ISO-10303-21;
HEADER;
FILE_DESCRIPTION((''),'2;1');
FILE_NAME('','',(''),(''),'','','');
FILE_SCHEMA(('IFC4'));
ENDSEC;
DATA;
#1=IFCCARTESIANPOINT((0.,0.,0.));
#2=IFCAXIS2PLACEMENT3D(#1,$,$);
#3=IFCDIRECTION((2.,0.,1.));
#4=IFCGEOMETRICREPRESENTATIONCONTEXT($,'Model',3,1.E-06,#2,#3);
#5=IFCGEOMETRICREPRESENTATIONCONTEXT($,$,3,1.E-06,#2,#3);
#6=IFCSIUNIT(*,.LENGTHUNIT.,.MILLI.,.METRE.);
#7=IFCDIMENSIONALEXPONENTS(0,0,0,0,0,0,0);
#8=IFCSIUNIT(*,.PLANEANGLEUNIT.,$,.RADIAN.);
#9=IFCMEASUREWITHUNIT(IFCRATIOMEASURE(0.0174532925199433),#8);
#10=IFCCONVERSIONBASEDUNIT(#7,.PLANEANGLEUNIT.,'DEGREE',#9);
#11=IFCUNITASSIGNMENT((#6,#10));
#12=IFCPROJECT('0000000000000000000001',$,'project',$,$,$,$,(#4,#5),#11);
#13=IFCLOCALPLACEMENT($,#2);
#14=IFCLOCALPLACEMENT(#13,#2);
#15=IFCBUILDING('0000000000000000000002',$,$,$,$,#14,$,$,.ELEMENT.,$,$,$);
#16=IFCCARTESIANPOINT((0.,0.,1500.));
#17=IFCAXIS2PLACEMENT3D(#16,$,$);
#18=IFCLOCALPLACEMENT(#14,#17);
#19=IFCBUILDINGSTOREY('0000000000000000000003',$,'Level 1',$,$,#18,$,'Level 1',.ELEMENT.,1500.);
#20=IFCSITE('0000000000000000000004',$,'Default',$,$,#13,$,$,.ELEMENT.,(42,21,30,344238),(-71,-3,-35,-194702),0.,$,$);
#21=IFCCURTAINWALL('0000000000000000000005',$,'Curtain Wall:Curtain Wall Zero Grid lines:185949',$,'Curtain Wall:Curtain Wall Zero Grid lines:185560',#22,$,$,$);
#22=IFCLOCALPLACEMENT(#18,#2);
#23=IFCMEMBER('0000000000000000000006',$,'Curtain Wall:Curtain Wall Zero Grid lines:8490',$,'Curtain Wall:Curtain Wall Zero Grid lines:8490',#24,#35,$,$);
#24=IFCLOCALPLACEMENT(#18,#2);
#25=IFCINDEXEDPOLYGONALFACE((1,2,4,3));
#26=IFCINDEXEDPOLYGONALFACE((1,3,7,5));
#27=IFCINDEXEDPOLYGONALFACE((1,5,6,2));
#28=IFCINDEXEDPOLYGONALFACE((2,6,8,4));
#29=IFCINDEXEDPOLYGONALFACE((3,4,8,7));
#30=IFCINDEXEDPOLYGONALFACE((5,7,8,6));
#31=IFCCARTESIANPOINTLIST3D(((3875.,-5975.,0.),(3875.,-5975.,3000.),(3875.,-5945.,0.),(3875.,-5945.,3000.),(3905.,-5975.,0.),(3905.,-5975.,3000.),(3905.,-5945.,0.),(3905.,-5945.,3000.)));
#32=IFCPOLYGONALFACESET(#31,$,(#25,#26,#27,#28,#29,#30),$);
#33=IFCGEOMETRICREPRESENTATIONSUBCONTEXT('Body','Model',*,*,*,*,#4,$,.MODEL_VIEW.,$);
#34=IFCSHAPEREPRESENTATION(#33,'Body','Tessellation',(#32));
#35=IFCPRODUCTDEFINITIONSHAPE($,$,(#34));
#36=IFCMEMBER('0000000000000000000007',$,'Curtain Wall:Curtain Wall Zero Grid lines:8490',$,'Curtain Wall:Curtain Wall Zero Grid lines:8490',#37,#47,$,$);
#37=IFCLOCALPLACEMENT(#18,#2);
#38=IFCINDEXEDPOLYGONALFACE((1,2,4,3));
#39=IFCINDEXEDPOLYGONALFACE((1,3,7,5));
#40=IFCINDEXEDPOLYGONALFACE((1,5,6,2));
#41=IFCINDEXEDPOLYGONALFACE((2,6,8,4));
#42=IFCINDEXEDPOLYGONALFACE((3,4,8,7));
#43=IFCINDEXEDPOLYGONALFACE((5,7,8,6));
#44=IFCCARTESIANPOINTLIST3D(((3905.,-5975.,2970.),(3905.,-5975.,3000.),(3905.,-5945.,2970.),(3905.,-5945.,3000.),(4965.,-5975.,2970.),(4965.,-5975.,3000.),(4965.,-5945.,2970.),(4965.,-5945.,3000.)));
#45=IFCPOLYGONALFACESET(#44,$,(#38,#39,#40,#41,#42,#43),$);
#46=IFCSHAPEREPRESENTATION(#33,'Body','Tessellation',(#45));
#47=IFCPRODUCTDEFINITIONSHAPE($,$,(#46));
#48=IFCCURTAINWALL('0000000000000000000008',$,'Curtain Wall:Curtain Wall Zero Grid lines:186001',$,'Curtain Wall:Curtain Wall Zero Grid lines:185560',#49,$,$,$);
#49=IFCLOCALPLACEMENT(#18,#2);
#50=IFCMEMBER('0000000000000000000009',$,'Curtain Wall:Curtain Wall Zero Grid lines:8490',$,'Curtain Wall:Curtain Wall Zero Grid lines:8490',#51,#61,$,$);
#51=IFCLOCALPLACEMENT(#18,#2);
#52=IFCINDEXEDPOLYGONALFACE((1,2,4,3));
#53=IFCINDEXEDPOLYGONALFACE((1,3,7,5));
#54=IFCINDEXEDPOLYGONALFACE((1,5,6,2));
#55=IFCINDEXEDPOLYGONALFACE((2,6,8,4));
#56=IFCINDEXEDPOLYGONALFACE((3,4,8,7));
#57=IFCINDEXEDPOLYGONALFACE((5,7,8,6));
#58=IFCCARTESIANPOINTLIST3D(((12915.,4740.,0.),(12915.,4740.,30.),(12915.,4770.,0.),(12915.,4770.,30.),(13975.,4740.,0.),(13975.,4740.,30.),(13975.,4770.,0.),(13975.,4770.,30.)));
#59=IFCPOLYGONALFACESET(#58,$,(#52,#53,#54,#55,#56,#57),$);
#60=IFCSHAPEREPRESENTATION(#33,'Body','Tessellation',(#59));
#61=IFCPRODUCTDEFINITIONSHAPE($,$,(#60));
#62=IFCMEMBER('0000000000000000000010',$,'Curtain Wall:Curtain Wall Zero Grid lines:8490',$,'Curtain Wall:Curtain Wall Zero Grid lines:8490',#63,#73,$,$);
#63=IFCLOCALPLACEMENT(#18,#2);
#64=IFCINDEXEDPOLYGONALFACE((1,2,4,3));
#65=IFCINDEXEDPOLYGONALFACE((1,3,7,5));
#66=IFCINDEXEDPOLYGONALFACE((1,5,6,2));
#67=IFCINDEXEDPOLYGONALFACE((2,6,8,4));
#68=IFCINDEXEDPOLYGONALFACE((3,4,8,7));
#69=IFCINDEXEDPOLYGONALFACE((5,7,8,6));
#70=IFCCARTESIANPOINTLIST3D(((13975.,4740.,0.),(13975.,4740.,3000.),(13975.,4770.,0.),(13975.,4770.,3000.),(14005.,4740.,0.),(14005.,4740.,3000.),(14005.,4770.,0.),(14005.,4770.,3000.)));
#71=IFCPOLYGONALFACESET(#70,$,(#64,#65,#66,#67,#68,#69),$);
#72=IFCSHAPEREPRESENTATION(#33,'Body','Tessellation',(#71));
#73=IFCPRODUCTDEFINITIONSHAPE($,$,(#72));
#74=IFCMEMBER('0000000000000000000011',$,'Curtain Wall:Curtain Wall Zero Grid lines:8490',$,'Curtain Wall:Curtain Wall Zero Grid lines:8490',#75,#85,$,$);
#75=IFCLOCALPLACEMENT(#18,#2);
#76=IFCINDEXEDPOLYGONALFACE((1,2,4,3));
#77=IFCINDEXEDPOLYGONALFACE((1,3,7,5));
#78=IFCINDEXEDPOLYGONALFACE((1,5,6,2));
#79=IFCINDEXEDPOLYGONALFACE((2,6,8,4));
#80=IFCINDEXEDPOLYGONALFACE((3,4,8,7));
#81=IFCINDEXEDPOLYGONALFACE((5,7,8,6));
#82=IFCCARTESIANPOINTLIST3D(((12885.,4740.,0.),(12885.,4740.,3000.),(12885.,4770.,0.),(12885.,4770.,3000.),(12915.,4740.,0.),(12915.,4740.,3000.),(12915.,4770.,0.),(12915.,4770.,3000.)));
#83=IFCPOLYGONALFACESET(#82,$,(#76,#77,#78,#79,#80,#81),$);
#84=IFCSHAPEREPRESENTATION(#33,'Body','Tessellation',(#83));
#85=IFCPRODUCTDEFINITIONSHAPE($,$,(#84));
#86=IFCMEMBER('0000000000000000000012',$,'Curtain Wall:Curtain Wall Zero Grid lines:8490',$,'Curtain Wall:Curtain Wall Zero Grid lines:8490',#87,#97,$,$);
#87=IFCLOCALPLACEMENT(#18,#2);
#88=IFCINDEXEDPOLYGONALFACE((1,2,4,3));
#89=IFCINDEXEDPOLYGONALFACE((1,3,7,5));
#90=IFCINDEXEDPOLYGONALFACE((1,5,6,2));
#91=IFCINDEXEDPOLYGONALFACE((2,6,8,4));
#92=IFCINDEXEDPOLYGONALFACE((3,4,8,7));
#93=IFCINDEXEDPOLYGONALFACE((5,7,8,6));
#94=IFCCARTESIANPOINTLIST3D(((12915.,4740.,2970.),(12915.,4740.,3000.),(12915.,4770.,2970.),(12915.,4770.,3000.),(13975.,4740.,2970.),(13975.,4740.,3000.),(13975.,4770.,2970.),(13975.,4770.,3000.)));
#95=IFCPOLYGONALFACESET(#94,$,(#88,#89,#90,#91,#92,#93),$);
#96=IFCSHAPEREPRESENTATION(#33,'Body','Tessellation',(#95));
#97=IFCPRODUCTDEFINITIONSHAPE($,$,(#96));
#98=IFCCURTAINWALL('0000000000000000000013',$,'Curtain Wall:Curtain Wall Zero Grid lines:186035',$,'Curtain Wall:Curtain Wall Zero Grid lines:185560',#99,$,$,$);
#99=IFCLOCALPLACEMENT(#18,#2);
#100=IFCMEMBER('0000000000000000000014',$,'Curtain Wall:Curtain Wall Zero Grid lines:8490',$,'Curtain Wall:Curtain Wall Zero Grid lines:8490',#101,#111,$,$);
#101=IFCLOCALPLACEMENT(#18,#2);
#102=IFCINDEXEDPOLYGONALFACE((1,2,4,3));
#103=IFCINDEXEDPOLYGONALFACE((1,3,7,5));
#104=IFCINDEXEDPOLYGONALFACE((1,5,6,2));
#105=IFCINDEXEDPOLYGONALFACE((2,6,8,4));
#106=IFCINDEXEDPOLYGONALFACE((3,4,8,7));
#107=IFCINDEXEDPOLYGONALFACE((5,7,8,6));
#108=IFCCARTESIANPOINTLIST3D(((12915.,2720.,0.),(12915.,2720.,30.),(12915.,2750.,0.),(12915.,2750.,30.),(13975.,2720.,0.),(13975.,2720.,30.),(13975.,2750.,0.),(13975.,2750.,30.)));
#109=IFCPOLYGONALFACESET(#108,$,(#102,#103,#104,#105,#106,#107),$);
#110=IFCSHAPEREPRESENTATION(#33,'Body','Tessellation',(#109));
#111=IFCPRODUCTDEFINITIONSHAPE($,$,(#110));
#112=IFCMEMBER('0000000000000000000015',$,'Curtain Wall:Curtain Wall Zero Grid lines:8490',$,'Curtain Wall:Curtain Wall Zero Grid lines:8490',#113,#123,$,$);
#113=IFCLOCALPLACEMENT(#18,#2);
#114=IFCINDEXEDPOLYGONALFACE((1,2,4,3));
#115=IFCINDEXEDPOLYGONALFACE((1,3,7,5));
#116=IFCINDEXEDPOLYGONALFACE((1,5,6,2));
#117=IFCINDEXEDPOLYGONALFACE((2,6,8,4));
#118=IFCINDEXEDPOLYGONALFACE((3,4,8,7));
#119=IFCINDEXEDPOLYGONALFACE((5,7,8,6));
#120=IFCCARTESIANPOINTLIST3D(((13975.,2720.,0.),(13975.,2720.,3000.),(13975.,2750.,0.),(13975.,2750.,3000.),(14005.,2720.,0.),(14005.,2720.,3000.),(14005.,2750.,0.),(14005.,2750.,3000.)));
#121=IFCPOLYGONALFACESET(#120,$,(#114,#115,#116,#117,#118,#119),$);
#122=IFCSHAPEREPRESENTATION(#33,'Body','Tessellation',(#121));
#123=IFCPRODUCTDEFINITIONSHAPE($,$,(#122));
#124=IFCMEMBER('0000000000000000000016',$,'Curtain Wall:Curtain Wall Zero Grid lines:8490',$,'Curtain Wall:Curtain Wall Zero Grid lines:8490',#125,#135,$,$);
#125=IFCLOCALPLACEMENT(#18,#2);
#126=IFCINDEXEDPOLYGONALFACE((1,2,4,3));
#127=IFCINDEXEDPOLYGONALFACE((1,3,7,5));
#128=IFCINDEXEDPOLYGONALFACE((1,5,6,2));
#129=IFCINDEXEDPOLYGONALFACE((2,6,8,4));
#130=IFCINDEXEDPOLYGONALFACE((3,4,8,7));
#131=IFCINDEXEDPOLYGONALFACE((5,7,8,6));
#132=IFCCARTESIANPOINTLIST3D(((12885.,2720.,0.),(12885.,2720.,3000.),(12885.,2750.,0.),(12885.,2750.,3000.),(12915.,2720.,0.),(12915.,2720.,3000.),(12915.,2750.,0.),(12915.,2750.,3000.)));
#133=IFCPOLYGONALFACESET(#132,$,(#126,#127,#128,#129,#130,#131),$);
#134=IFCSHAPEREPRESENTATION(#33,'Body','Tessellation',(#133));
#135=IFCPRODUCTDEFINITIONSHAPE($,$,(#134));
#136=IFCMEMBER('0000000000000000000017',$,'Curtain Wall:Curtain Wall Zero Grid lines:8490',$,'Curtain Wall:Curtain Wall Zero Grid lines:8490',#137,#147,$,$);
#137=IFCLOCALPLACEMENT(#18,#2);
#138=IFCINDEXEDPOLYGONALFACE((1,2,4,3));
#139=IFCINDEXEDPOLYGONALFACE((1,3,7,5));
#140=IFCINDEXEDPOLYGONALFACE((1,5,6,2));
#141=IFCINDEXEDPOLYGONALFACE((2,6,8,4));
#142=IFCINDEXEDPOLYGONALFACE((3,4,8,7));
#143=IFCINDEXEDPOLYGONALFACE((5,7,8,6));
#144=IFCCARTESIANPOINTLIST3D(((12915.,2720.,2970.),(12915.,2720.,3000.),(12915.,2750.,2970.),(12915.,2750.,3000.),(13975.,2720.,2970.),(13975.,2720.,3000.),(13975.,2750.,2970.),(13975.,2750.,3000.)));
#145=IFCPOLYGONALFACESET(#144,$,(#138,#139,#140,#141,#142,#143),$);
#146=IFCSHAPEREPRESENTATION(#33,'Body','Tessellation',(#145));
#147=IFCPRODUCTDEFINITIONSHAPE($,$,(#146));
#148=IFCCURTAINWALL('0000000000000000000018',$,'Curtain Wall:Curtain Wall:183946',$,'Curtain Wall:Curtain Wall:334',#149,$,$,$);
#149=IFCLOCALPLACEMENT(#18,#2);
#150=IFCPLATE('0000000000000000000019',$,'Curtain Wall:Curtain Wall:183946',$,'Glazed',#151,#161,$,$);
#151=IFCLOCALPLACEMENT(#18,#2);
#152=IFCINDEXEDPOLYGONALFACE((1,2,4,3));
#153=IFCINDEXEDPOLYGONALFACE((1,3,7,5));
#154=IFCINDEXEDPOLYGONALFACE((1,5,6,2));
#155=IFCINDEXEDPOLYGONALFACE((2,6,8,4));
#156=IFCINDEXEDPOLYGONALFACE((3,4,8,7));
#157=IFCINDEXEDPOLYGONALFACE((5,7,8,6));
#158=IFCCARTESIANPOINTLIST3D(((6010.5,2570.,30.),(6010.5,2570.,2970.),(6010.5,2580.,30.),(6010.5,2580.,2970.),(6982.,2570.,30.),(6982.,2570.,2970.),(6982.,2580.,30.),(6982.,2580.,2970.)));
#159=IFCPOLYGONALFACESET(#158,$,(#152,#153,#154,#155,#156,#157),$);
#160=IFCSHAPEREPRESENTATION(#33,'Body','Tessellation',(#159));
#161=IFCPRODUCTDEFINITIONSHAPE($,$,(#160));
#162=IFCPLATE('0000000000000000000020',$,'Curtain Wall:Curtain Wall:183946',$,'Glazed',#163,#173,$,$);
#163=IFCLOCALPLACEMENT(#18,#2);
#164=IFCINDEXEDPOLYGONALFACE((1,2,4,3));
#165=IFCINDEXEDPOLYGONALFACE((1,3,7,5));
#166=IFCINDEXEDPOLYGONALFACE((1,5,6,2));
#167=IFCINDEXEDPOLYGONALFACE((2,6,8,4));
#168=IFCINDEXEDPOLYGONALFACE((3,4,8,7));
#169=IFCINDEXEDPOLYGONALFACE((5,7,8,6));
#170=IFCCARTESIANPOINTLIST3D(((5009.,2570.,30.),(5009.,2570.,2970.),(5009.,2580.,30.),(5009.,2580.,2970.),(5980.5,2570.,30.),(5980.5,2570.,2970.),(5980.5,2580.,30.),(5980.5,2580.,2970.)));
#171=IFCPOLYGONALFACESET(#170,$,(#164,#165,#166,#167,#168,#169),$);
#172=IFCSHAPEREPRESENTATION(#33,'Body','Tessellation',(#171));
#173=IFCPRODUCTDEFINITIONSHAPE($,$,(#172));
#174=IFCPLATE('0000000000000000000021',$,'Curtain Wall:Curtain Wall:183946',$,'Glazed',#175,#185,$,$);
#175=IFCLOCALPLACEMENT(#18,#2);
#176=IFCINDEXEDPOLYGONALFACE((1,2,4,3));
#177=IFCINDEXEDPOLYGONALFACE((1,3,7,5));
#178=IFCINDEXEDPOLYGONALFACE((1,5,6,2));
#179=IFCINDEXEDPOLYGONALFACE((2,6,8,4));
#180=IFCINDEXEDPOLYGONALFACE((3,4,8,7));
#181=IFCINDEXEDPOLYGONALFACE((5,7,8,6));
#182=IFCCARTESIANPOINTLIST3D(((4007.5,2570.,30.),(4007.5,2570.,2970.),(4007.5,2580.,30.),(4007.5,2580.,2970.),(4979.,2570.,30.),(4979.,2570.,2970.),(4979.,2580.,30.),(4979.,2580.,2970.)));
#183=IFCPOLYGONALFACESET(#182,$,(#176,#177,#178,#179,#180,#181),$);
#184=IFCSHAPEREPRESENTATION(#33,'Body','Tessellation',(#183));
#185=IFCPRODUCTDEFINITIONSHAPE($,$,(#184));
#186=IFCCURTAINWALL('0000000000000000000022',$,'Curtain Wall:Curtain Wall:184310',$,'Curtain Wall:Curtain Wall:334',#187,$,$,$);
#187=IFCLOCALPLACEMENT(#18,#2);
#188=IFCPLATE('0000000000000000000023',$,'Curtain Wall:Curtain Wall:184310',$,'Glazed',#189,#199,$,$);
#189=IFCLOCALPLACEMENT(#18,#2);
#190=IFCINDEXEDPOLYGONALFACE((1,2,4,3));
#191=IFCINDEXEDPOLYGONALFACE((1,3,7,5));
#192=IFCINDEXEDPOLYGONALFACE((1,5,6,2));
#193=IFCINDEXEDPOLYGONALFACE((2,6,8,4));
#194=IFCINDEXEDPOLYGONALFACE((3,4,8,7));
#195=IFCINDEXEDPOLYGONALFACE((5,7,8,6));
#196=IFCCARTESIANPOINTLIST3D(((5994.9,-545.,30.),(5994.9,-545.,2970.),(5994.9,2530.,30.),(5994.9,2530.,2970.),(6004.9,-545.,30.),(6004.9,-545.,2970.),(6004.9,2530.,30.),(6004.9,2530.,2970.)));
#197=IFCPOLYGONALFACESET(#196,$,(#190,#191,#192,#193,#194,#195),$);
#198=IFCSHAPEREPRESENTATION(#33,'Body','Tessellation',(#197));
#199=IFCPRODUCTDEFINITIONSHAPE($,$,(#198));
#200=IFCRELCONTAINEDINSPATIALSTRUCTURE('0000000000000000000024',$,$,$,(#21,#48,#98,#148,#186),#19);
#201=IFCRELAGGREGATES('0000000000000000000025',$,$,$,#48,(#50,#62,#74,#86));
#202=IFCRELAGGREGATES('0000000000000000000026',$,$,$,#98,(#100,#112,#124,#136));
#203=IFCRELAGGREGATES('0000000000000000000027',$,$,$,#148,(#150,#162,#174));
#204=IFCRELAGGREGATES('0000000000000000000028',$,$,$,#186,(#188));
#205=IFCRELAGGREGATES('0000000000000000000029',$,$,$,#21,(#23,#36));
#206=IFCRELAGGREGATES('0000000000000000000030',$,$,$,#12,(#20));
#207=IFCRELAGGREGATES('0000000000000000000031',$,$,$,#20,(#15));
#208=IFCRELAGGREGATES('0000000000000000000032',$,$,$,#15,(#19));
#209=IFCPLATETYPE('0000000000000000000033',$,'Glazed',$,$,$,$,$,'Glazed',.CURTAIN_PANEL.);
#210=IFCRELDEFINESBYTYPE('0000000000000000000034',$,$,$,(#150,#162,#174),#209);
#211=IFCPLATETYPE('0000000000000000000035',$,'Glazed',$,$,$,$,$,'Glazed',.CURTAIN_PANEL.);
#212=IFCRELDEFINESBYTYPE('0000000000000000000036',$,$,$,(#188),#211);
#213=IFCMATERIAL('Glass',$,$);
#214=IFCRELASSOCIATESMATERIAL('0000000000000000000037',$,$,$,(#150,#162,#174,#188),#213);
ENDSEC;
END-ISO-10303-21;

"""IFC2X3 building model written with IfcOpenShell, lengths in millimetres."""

from ifc_helpers import new_model, entity, si_unit, converted_unit, direction, frame, frame_2d, origin, origin_2d_with_axis, place, context, subcontext, project, spatial, rectangle, extrude, source, transform, mapped, material, type_object, type_shapes, element, aggregate, save


model = new_model("IFC2X3")

# Units and contexts
model_context = context("Model", 3, precision=1e-06, world=origin(), true_north=direction((2.0, 0.0, 1.0)))
context_of_model = context(None, 3, precision=1e-06, world=origin(), true_north=direction((2.0, 0.0, 1.0)))
body_context = subcontext(model_context, "Body", "Model", "MODEL_VIEW")
ifc_project = project(units=[si_unit("LENGTHUNIT", "METRE", prefix="MILLI"), converted_unit("PLANEANGLEUNIT", "DEGREE", entity("IfcRatioMeasure", 0.0174532925199433), si_unit("PLANEANGLEUNIT", "RADIAN"), dimensions=[0, 0, 0, 0, 0, 0, 0])], contexts=[model_context, context_of_model])

# Site, building, storey
site_placement = place(None, origin())
site = spatial("IfcSite", under=ifc_project, at=site_placement, Name="Default", CompositionType="ELEMENT", RefLatitude=(42, 21, 30, 344238), RefLongitude=(-71, -3, -35, -194702), RefElevation=0.0)
building_placement = place(site_placement, origin())
building = spatial("IfcBuilding", under=site, at=building_placement, CompositionType="ELEMENT")
storey_placement = place(building_placement, frame((0.0, 0.0, 1500.0)))
storey = spatial("IfcBuildingStorey", under=building, at=storey_placement, Name="Level 1", LongName="Level 1", CompositionType="ELEMENT", Elevation=1500.0)

# Curtain walls, members
curtain_wall_1_placement = place(storey_placement, origin())
curtain_wall_1 = element("IfcCurtainWall", 1, at=curtain_wall_1_placement, inside=storey, Name="Curtain Wall:Curtain Wall Zero Grid lines:185949", ObjectType="Curtain Wall:Curtain Wall Zero Grid lines:185560")
member_1_placement = place(storey_placement, origin())
member_1 = element("IfcMember", 2, at=member_1_placement, Name="Curtain Wall:Curtain Wall Zero Grid lines:8490", ObjectType="Curtain Wall:Curtain Wall Zero Grid lines:8490", context=body_context, shape_type="SweptSolid", body=[
    extrude(rectangle(XDim=30.0, YDim=30.0, at=origin_2d_with_axis()), frame((3890.0, -5960.0, 0.0)), (0.0, 0.0, 1.0), 3000.0),
])
member_2_placement = place(storey_placement, origin())
member_2 = element("IfcMember", 3, at=member_2_placement, Name="Curtain Wall:Curtain Wall Zero Grid lines:8490", ObjectType="Curtain Wall:Curtain Wall Zero Grid lines:8490", context=body_context, shape_type="SweptSolid", body=[
    extrude(rectangle(XDim=1060.0, YDim=30.0, at=frame_2d((0.0, 0.0), x_axis=(1.0, 0.0))), frame((4435.0, -5960.0, 2970.0), z_axis=(0.0, 0.0, 1.0), x_axis=(-1.0, 0.0, 0.0)), (0.0, 0.0, 1.0), 30.0),
])
curtain_wall_2_placement = place(storey_placement, origin())
curtain_wall_2 = element("IfcCurtainWall", 4, at=curtain_wall_2_placement, inside=storey, Name="Curtain Wall:Curtain Wall Zero Grid lines:186001", ObjectType="Curtain Wall:Curtain Wall Zero Grid lines:185560")
member_3_placement = place(storey_placement, origin())
member_3 = element("IfcMember", 5, at=member_3_placement, Name="Curtain Wall:Curtain Wall Zero Grid lines:8490", ObjectType="Curtain Wall:Curtain Wall Zero Grid lines:8490", context=body_context, shape_type="SweptSolid", body=[
    extrude(rectangle(XDim=1060.0, YDim=30.0, at=frame_2d((0.0, 0.0), x_axis=(1.0, 0.0))), frame((13445.0, 4755.0, 0.0)), (0.0, 0.0, 1.0), 30.0),
])
member_4_placement = place(storey_placement, origin())
member_4 = element("IfcMember", 6, at=member_4_placement, Name="Curtain Wall:Curtain Wall Zero Grid lines:8490", ObjectType="Curtain Wall:Curtain Wall Zero Grid lines:8490", context=body_context, shape_type="SweptSolid", body=[
    extrude(rectangle(XDim=30.0, YDim=30.0, at=frame_2d((0.0, 0.0), x_axis=(1.0, 0.0))), frame((13990.0, 4755.0, 0.0), z_axis=(0.0, 0.0, 1.0), x_axis=(0.0, 1.0, 0.0)), (0.0, 0.0, 1.0), 3000.0),
])
member_5_placement = place(storey_placement, origin())
member_5 = element("IfcMember", 7, at=member_5_placement, Name="Curtain Wall:Curtain Wall Zero Grid lines:8490", ObjectType="Curtain Wall:Curtain Wall Zero Grid lines:8490", context=body_context, shape_type="SweptSolid", body=[
    extrude(rectangle(XDim=30.0, YDim=30.0, at=frame_2d((0.0, 0.0), x_axis=(1.0, 0.0))), frame((12900.0, 4755.0, 0.0)), (0.0, 0.0, 1.0), 3000.0),
])
member_6_placement = place(storey_placement, origin())
member_6 = element("IfcMember", 8, at=member_6_placement, Name="Curtain Wall:Curtain Wall Zero Grid lines:8490", ObjectType="Curtain Wall:Curtain Wall Zero Grid lines:8490", context=body_context, shape_type="SweptSolid", body=[
    extrude(rectangle(XDim=1060.0, YDim=30.0, at=frame_2d((0.0, 0.0), x_axis=(1.0, 0.0))), frame((13445.0, 4755.0, 2970.0), z_axis=(0.0, 0.0, 1.0), x_axis=(-1.0, 0.0, 0.0)), (0.0, 0.0, 1.0), 30.0),
])
aggregate(curtain_wall_2, [member_3, member_4, member_5, member_6])
curtain_wall_3_placement = place(storey_placement, origin())
curtain_wall_3 = element("IfcCurtainWall", 9, at=curtain_wall_3_placement, inside=storey, Name="Curtain Wall:Curtain Wall Zero Grid lines:186035", ObjectType="Curtain Wall:Curtain Wall Zero Grid lines:185560")
member_7_placement = place(storey_placement, origin())
member_7 = element("IfcMember", 10, at=member_7_placement, Name="Curtain Wall:Curtain Wall Zero Grid lines:8490", ObjectType="Curtain Wall:Curtain Wall Zero Grid lines:8490", context=body_context, shape_type="SweptSolid", body=[
    extrude(rectangle(XDim=1060.0, YDim=30.0, at=frame_2d((0.0, 0.0), x_axis=(1.0, 0.0))), frame((13445.0, 2735.0, 0.0)), (0.0, 0.0, 1.0), 30.0),
])
member_8_placement = place(storey_placement, origin())
member_8 = element("IfcMember", 11, at=member_8_placement, Name="Curtain Wall:Curtain Wall Zero Grid lines:8490", ObjectType="Curtain Wall:Curtain Wall Zero Grid lines:8490", context=body_context, shape_type="SweptSolid", body=[
    extrude(rectangle(XDim=30.0, YDim=30.0, at=frame_2d((0.0, 0.0), x_axis=(1.0, 0.0))), frame((13990.0, 2735.0, 0.0), z_axis=(0.0, 0.0, 1.0), x_axis=(0.0, 1.0, 0.0)), (0.0, 0.0, 1.0), 3000.0),
])
member_9_placement = place(storey_placement, origin())
member_9 = element("IfcMember", 12, at=member_9_placement, Name="Curtain Wall:Curtain Wall Zero Grid lines:8490", ObjectType="Curtain Wall:Curtain Wall Zero Grid lines:8490", context=body_context, shape_type="SweptSolid", body=[
    extrude(rectangle(XDim=30.0, YDim=30.0, at=frame_2d((0.0, 0.0), x_axis=(1.0, 0.0))), frame((12900.0, 2735.0, 0.0)), (0.0, 0.0, 1.0), 3000.0),
])
member_10_placement = place(storey_placement, origin())
member_10 = element("IfcMember", 13, at=member_10_placement, Name="Curtain Wall:Curtain Wall Zero Grid lines:8490", ObjectType="Curtain Wall:Curtain Wall Zero Grid lines:8490", context=body_context, shape_type="SweptSolid", body=[
    extrude(rectangle(XDim=1060.0, YDim=30.0, at=frame_2d((0.0, 0.0), x_axis=(1.0, 0.0))), frame((13445.0, 2735.0, 2970.0), z_axis=(0.0, 0.0, 1.0), x_axis=(-1.0, 0.0, 0.0)), (0.0, 0.0, 1.0), 30.0),
])
aggregate(curtain_wall_3, [member_7, member_8, member_9, member_10])

# Curtain walls, plates
curtain_wall_4_placement = place(storey_placement, origin())
curtain_wall_4 = element("IfcCurtainWall", 14, at=curtain_wall_4_placement, inside=storey, Name="Curtain Wall:Curtain Wall:183946", ObjectType="Curtain Wall:Curtain Wall:334")
ifc_material = material(Name="Glass")
plate_type_1 = type_object("IfcPlateType", Name="Glazed", ElementType="Glazed", PredefinedType="CURTAIN_PANEL")
shared_shape_1 = source(origin(), body_context, "Body", "SweptSolid", [
    extrude(rectangle(XDim=10.0, YDim=971.5, at=origin_2d_with_axis()), frame((0.0, 0.0, 0.0), z_axis=(0.0, 0.0, 1.0), x_axis=(0.0, 1.0, 0.0)), (0.0, 0.0, 1.0), 2940.0),
])
type_shapes(plate_type_1, [shared_shape_1])
plate_1_placement = place(storey_placement, frame((6496.2, 2575.0, 30.0), z_axis=(0.0, 0.0, 1.0), x_axis=(-1.0, 0.0, 0.0)))
plate_1 = element("IfcPlate", 15, at=plate_1_placement, type_object=plate_type_1, material=ifc_material, Name="Curtain Wall:Curtain Wall:183946", ObjectType="Glazed", context=body_context, shape_type="MappedRepresentation", body=[
    mapped(shared_shape_1, transform((0.0, 0.0, 0.0), scale=1.0)),
])
plate_2_placement = place(storey_placement, frame((5494.8, 2575.0, 30.0), z_axis=(0.0, 0.0, 1.0), x_axis=(-1.0, 0.0, 0.0)))
plate_2 = element("IfcPlate", 16, at=plate_2_placement, type_object=plate_type_1, material=ifc_material, Name="Curtain Wall:Curtain Wall:183946", ObjectType="Glazed", context=body_context, shape_type="MappedRepresentation", body=[
    mapped(shared_shape_1, transform((0.0, 0.0, 0.0), scale=1.0)),
])
plate_3_placement = place(storey_placement, frame((4493.2, 2575.0, 30.0), z_axis=(0.0, 0.0, 1.0), x_axis=(-1.0, 0.0, 0.0)))
plate_3 = element("IfcPlate", 17, at=plate_3_placement, type_object=plate_type_1, material=ifc_material, Name="Curtain Wall:Curtain Wall:183946", ObjectType="Glazed", context=body_context, shape_type="MappedRepresentation", body=[
    mapped(shared_shape_1, transform((0.0, 0.0, 0.0), scale=1.0)),
])
aggregate(curtain_wall_4, [plate_1, plate_2, plate_3])
curtain_wall_5_placement = place(storey_placement, origin())
curtain_wall_5 = element("IfcCurtainWall", 18, at=curtain_wall_5_placement, inside=storey, Name="Curtain Wall:Curtain Wall:184310", ObjectType="Curtain Wall:Curtain Wall:334")
plate_type_2 = type_object("IfcPlateType", Name="Glazed", ElementType="Glazed", PredefinedType="CURTAIN_PANEL")
shared_shape_2 = source(origin(), body_context, "Body", "SweptSolid", [
    extrude(rectangle(XDim=10.0, YDim=3075.0, at=origin_2d_with_axis()), frame((0.0, 0.0, 0.0), z_axis=(0.0, 0.0, 1.0), x_axis=(0.0, 1.0, 0.0)), (0.0, 0.0, 1.0), 2940.0),
])
type_shapes(plate_type_2, [shared_shape_2])
plate_4_placement = place(storey_placement, frame((5999.9, 992.5, 30.0), z_axis=(0.0, 0.0, 1.0), x_axis=(0.0, -1.0, 0.0)))
plate_4 = element("IfcPlate", 19, at=plate_4_placement, type_object=plate_type_2, material=ifc_material, Name="Curtain Wall:Curtain Wall:184310", ObjectType="Glazed", context=body_context, shape_type="MappedRepresentation", body=[
    mapped(shared_shape_2, transform((0.0, 0.0, 0.0), scale=1.0)),
])
aggregate(curtain_wall_5, [plate_4])

aggregate(curtain_wall_1, [member_1, member_2])

save(model, "model.ifc")
